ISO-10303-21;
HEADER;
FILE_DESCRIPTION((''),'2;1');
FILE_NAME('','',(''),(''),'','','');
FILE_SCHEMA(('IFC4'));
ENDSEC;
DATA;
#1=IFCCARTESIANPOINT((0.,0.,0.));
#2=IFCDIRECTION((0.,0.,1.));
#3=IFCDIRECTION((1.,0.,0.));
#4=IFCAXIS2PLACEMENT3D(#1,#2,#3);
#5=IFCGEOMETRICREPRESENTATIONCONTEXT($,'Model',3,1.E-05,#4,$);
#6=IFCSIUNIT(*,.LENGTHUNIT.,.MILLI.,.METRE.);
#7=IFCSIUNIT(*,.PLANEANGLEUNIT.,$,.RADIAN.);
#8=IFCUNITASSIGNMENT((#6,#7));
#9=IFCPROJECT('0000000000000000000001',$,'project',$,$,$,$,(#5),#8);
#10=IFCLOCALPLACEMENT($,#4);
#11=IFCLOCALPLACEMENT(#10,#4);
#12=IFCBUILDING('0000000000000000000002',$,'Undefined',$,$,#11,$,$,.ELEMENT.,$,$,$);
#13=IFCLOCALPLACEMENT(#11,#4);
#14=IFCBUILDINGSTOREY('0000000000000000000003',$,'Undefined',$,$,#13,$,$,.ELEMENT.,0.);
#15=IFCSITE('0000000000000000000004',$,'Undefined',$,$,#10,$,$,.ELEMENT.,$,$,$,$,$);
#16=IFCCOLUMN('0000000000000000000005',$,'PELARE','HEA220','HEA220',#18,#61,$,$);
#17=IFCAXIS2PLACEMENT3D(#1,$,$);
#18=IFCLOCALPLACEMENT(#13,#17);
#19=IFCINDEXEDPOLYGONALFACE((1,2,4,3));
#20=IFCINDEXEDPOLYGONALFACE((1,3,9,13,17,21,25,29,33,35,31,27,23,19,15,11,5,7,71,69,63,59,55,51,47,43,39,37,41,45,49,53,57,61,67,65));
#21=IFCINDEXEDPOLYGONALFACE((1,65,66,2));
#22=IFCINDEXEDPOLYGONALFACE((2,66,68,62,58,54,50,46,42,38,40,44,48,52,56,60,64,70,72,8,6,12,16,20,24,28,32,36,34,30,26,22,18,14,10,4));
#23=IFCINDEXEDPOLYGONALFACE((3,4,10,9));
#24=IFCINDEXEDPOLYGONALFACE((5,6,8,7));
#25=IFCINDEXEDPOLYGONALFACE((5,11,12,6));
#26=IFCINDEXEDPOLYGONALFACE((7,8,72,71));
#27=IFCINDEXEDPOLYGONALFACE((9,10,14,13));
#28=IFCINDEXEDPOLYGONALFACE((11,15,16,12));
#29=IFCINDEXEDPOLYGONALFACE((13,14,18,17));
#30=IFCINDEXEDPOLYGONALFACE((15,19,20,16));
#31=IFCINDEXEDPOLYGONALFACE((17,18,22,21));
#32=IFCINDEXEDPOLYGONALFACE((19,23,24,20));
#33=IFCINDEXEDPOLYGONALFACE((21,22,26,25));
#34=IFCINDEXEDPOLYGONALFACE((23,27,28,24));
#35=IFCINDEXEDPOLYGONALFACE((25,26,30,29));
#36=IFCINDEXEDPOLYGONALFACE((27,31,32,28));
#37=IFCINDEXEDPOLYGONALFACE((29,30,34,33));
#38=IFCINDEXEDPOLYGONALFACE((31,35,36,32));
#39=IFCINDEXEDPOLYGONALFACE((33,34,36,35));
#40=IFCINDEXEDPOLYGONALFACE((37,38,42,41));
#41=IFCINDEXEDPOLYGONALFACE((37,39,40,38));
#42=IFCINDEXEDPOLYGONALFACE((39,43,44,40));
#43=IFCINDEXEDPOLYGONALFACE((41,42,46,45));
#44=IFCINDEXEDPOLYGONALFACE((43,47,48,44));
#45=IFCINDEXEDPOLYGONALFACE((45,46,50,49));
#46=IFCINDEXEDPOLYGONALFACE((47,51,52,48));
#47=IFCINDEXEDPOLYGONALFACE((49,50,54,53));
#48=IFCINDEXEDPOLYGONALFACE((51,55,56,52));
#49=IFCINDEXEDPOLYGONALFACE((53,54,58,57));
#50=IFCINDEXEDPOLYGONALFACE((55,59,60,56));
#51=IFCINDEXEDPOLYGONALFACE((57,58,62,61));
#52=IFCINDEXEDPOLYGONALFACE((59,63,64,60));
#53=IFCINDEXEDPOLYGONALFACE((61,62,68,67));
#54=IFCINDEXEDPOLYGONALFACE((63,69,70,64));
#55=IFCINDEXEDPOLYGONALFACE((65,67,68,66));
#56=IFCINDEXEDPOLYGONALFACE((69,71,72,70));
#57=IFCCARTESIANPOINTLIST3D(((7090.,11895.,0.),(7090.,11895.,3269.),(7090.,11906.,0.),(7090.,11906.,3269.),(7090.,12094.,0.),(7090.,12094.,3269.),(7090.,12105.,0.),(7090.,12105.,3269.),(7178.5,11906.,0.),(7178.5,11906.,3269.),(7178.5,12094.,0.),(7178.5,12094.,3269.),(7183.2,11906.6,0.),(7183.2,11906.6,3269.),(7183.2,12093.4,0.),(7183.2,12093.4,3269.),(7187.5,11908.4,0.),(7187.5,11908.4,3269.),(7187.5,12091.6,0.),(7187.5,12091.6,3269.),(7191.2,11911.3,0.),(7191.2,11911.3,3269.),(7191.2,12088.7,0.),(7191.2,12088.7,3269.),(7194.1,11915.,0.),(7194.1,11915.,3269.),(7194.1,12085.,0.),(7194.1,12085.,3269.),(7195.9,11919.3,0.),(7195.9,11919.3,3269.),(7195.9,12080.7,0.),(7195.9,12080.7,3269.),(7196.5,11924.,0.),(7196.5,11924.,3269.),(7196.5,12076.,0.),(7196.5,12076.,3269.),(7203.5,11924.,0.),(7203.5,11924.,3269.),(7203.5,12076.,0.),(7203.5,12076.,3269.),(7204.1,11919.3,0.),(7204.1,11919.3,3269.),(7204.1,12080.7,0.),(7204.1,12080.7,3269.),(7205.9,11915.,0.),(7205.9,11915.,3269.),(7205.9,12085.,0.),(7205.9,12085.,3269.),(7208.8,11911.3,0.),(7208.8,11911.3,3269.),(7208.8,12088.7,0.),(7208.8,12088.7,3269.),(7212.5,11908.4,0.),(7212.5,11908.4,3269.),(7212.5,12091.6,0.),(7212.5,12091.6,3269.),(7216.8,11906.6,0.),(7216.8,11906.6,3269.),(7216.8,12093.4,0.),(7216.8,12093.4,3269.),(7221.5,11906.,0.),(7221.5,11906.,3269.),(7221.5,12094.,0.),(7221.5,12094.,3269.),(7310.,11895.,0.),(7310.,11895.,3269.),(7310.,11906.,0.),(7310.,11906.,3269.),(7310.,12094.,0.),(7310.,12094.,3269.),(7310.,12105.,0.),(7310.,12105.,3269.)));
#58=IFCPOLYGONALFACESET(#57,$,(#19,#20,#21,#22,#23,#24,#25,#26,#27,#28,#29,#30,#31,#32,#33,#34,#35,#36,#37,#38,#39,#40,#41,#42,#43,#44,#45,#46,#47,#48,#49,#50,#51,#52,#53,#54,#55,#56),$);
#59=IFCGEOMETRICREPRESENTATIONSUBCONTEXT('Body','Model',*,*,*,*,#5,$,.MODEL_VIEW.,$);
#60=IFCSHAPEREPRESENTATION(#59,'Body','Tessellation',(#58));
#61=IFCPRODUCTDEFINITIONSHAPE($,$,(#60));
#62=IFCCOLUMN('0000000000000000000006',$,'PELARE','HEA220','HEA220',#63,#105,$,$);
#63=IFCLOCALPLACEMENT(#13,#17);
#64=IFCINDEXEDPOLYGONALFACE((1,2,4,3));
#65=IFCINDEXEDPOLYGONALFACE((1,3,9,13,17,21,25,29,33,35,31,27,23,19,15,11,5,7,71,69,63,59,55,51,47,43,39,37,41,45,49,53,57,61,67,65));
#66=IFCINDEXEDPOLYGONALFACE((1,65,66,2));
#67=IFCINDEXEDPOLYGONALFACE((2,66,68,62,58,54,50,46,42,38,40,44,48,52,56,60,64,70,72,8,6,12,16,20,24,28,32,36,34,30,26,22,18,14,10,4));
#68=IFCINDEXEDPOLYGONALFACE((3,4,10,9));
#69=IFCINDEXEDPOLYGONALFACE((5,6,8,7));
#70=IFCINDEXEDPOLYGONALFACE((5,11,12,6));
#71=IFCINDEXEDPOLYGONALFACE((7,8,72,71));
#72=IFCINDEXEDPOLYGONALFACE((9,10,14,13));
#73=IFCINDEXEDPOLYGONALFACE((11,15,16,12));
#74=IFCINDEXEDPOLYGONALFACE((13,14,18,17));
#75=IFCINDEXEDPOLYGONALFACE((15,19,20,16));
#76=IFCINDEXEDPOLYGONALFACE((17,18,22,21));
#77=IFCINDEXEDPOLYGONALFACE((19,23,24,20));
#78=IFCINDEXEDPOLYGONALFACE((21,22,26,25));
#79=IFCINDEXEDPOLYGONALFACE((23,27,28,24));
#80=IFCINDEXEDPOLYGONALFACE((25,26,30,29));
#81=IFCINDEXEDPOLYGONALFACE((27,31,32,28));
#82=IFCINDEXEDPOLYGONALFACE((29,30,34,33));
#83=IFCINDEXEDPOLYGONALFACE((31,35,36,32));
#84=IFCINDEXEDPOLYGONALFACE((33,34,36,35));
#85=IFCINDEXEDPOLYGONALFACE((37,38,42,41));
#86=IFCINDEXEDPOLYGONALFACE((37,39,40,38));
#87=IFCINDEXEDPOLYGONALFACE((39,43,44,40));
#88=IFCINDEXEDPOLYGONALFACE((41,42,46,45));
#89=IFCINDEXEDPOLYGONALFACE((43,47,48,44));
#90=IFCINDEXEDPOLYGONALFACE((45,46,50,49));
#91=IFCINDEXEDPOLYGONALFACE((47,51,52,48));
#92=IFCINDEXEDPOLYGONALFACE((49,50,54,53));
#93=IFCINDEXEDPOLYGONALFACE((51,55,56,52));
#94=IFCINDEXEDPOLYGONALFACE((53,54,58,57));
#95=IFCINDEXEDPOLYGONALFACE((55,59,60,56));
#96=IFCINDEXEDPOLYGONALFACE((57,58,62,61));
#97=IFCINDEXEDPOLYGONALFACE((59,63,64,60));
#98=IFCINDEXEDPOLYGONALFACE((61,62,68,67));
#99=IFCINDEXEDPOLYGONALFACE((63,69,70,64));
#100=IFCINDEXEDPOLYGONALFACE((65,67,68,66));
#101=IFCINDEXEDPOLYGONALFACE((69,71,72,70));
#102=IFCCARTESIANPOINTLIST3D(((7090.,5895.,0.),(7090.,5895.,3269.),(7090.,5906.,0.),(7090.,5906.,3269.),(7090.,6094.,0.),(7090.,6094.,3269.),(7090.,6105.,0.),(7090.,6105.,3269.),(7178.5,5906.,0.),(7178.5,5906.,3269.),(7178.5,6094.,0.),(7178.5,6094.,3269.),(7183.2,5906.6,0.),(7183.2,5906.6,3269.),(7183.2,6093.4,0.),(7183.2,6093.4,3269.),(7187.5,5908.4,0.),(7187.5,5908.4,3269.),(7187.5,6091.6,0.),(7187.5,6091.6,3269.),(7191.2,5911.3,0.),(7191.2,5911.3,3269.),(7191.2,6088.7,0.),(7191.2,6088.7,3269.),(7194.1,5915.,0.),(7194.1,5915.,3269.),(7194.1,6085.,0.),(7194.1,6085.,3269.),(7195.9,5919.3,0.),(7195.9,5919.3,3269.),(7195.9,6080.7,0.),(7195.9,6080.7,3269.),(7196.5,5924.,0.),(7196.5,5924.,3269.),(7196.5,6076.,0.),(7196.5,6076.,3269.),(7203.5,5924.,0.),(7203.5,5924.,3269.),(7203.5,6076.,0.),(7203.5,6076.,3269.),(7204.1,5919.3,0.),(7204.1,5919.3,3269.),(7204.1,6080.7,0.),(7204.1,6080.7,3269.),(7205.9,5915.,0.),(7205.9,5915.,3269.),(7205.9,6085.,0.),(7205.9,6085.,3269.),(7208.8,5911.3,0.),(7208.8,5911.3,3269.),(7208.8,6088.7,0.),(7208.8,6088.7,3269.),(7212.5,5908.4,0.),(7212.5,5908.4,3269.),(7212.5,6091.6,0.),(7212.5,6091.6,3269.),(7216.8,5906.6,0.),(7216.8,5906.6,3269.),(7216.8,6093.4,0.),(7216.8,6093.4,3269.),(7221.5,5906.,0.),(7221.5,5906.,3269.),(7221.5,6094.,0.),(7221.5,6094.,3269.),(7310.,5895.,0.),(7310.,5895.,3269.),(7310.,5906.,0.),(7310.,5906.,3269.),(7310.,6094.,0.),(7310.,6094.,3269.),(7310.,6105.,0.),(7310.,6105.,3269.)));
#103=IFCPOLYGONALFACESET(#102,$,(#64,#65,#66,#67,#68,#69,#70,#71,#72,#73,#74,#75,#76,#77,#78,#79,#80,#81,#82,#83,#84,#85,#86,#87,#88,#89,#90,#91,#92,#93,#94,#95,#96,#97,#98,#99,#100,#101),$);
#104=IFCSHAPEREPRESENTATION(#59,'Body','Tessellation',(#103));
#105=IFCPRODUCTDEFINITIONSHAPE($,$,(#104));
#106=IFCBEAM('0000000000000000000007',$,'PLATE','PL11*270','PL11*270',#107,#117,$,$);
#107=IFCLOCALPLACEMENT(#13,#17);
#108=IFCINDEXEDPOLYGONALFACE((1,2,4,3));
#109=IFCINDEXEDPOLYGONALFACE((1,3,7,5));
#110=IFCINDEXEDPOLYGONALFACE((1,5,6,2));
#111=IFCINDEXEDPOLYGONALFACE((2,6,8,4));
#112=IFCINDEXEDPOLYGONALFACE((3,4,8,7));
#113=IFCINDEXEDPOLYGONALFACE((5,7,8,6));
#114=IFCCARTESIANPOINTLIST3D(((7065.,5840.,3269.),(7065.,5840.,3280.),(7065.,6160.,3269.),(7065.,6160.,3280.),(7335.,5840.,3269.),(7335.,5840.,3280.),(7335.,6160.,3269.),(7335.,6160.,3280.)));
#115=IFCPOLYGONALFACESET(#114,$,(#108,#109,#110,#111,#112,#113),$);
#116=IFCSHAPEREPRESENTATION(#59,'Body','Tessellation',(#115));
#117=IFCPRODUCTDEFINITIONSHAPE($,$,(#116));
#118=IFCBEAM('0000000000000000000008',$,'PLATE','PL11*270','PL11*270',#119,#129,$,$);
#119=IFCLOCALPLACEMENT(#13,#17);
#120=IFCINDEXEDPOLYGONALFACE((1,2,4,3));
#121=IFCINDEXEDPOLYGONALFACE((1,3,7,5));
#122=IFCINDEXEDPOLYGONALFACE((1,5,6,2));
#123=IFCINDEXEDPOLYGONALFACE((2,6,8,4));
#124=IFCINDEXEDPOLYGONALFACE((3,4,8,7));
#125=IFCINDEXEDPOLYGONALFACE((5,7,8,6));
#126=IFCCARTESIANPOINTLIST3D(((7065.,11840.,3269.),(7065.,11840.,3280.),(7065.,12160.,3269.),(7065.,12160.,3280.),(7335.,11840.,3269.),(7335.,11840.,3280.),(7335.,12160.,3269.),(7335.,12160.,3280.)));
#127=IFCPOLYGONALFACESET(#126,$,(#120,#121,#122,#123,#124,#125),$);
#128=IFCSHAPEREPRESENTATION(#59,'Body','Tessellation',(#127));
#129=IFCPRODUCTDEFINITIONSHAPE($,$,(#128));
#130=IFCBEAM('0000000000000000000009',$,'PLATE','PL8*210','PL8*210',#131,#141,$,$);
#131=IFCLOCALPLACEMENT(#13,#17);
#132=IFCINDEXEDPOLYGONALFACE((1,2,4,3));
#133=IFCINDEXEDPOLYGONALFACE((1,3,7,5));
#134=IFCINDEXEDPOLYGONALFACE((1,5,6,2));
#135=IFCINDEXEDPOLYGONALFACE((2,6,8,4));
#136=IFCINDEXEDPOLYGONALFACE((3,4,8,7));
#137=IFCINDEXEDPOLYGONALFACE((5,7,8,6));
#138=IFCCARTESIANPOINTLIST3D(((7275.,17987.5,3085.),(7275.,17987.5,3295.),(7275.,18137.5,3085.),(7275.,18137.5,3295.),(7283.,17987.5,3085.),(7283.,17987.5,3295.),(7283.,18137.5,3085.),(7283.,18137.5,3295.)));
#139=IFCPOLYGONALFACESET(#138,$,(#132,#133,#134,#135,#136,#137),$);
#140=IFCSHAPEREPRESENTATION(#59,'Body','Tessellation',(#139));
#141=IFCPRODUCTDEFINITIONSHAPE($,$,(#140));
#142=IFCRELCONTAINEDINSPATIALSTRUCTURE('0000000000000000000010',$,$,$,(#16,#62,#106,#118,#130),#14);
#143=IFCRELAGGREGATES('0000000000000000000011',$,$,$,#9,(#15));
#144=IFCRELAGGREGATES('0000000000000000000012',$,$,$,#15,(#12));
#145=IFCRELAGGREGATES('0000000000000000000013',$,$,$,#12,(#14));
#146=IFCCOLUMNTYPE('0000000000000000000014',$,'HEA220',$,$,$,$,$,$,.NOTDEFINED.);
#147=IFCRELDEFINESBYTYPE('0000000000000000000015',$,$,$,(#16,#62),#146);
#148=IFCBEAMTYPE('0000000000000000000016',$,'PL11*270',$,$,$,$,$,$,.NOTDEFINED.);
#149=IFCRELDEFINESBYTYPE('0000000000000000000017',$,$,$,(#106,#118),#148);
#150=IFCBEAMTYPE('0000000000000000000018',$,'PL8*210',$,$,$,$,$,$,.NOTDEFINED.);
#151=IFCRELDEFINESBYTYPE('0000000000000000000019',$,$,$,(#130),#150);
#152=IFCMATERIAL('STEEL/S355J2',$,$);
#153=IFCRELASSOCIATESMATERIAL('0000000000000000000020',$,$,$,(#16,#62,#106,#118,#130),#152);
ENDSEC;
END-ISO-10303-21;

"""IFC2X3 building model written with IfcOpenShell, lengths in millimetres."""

from ifc_helpers import new_model, si_unit, frame, origin_with_axes, origin_2d_with_axis, place, context, subcontext, project, spatial, rectangle, i_section, extrude, clip, halfspace, material, type_object, element, save


model = new_model("IFC2X3")

# Units and contexts
model_context = context("Model", 3, precision=1e-05, world=origin_with_axes())
body_context = subcontext(model_context, "Body", "Model", "MODEL_VIEW")
ifc_project = project(units=[si_unit("LENGTHUNIT", "METRE", prefix="MILLI"), si_unit("PLANEANGLEUNIT", "RADIAN")], contexts=[model_context])

# Site, building, storey
site_placement = place(None, origin_with_axes())
site = spatial("IfcSite", under=ifc_project, at=site_placement, Name="Undefined", CompositionType="ELEMENT")
building_placement = place(site_placement, origin_with_axes())
building = spatial("IfcBuilding", under=site, at=building_placement, Name="Undefined", CompositionType="ELEMENT")
storey_placement = place(building_placement, origin_with_axes())
storey = spatial("IfcBuildingStorey", under=building, at=storey_placement, Name="Undefined", CompositionType="ELEMENT", Elevation=0.0)

# Columns
ifc_material_1 = material(Name="STEEL/S355J2")
column_type = type_object("IfcColumnType", Name="HEA220", PredefinedType="NOTDEFINED")
for number, where, z_axis, x_axis, name in (
    (1, (7200.0, 12000.0, 0.0), (0.0, 0.0, 1.0), (0.0, 1.0, 0.0), "PELARE"),
    (2, (7200.0, 6000.0, 0.0), (0.0, 0.0, 1.0), (0.0, 1.0, 0.0), "PELARE"),
):
    element("IfcColumn", number, at=place(storey_placement, frame(where, z_axis=z_axis, x_axis=x_axis)), inside=storey, type_object=column_type, material=ifc_material_1, Name=name, Description="HEA220", ObjectType="HEA220", context=body_context, shape_type="Clipping", body=[
        clip(extrude(i_section(OverallWidth=220.0, OverallDepth=210.0, WebThickness=7.0, FlangeThickness=11.0, FilletRadius=18.0, at=origin_2d_with_axis()), frame((0.0, 0.0, 3269.0), z_axis=(0.0, 0.0, -1.0), x_axis=(0.0, 1.0, 0.0)), (0.0, 0.0, 1.0), 3269.0), halfspace(frame((-160.0, 0.0, 3269.0), z_axis=(0.0, 0.0, 1.0), x_axis=(0.0, 1.0, 0.0)), False)),
    ])

# Beams
beam_type_1 = type_object("IfcBeamType", Name="PL11*270", PredefinedType="NOTDEFINED")
for number, where, z_axis, x_axis, name in (
    (3, (7200.0, 5840.0, 3274.5), (-1.0, 0.0, 0.0), (0.0, 1.0, 0.0), "PLATE"),
    (4, (7200.0, 11840.0, 3274.5), (-1.0, 0.0, 0.0), (0.0, 1.0, 0.0), "PLATE"),
):
    element("IfcBeam", number, at=place(storey_placement, frame(where, z_axis=z_axis, x_axis=x_axis)), inside=storey, type_object=beam_type_1, material=ifc_material_1, Name=name, Description="PL11*270", ObjectType="PL11*270", context=body_context, shape_type="SweptSolid", body=[
        extrude(rectangle(XDim=11.0, YDim=270.0, at=origin_2d_with_axis()), frame((320.0, 0.0, 0.0), z_axis=(-1.0, 0.0, 0.0), x_axis=(0.0, -1.0, 0.0)), (0.0, 0.0, 1.0), 320.0),
    ])
beam_type_2 = type_object("IfcBeamType", Name="PL8*210", PredefinedType="NOTDEFINED")
beam_1_placement = place(storey_placement, frame((7279.0, 17987.5, 3190.0), z_axis=(0.0, 0.0, 1.0), x_axis=(0.0, 1.0, 0.0)))
element("IfcBeam", 5, at=beam_1_placement, inside=storey, type_object=beam_type_2, material=ifc_material_1, Name="PLATE", Description="PL8*210", ObjectType="PL8*210", context=body_context, shape_type="SweptSolid", body=[
    extrude(rectangle(XDim=8.0, YDim=210.0, at=origin_2d_with_axis()), frame((150.0, 0.0, 0.0), z_axis=(-1.0, 0.0, 0.0), x_axis=(0.0, -1.0, 0.0)), (0.0, 0.0, 1.0), 150.0),
])

save(model, "model.ifc")
